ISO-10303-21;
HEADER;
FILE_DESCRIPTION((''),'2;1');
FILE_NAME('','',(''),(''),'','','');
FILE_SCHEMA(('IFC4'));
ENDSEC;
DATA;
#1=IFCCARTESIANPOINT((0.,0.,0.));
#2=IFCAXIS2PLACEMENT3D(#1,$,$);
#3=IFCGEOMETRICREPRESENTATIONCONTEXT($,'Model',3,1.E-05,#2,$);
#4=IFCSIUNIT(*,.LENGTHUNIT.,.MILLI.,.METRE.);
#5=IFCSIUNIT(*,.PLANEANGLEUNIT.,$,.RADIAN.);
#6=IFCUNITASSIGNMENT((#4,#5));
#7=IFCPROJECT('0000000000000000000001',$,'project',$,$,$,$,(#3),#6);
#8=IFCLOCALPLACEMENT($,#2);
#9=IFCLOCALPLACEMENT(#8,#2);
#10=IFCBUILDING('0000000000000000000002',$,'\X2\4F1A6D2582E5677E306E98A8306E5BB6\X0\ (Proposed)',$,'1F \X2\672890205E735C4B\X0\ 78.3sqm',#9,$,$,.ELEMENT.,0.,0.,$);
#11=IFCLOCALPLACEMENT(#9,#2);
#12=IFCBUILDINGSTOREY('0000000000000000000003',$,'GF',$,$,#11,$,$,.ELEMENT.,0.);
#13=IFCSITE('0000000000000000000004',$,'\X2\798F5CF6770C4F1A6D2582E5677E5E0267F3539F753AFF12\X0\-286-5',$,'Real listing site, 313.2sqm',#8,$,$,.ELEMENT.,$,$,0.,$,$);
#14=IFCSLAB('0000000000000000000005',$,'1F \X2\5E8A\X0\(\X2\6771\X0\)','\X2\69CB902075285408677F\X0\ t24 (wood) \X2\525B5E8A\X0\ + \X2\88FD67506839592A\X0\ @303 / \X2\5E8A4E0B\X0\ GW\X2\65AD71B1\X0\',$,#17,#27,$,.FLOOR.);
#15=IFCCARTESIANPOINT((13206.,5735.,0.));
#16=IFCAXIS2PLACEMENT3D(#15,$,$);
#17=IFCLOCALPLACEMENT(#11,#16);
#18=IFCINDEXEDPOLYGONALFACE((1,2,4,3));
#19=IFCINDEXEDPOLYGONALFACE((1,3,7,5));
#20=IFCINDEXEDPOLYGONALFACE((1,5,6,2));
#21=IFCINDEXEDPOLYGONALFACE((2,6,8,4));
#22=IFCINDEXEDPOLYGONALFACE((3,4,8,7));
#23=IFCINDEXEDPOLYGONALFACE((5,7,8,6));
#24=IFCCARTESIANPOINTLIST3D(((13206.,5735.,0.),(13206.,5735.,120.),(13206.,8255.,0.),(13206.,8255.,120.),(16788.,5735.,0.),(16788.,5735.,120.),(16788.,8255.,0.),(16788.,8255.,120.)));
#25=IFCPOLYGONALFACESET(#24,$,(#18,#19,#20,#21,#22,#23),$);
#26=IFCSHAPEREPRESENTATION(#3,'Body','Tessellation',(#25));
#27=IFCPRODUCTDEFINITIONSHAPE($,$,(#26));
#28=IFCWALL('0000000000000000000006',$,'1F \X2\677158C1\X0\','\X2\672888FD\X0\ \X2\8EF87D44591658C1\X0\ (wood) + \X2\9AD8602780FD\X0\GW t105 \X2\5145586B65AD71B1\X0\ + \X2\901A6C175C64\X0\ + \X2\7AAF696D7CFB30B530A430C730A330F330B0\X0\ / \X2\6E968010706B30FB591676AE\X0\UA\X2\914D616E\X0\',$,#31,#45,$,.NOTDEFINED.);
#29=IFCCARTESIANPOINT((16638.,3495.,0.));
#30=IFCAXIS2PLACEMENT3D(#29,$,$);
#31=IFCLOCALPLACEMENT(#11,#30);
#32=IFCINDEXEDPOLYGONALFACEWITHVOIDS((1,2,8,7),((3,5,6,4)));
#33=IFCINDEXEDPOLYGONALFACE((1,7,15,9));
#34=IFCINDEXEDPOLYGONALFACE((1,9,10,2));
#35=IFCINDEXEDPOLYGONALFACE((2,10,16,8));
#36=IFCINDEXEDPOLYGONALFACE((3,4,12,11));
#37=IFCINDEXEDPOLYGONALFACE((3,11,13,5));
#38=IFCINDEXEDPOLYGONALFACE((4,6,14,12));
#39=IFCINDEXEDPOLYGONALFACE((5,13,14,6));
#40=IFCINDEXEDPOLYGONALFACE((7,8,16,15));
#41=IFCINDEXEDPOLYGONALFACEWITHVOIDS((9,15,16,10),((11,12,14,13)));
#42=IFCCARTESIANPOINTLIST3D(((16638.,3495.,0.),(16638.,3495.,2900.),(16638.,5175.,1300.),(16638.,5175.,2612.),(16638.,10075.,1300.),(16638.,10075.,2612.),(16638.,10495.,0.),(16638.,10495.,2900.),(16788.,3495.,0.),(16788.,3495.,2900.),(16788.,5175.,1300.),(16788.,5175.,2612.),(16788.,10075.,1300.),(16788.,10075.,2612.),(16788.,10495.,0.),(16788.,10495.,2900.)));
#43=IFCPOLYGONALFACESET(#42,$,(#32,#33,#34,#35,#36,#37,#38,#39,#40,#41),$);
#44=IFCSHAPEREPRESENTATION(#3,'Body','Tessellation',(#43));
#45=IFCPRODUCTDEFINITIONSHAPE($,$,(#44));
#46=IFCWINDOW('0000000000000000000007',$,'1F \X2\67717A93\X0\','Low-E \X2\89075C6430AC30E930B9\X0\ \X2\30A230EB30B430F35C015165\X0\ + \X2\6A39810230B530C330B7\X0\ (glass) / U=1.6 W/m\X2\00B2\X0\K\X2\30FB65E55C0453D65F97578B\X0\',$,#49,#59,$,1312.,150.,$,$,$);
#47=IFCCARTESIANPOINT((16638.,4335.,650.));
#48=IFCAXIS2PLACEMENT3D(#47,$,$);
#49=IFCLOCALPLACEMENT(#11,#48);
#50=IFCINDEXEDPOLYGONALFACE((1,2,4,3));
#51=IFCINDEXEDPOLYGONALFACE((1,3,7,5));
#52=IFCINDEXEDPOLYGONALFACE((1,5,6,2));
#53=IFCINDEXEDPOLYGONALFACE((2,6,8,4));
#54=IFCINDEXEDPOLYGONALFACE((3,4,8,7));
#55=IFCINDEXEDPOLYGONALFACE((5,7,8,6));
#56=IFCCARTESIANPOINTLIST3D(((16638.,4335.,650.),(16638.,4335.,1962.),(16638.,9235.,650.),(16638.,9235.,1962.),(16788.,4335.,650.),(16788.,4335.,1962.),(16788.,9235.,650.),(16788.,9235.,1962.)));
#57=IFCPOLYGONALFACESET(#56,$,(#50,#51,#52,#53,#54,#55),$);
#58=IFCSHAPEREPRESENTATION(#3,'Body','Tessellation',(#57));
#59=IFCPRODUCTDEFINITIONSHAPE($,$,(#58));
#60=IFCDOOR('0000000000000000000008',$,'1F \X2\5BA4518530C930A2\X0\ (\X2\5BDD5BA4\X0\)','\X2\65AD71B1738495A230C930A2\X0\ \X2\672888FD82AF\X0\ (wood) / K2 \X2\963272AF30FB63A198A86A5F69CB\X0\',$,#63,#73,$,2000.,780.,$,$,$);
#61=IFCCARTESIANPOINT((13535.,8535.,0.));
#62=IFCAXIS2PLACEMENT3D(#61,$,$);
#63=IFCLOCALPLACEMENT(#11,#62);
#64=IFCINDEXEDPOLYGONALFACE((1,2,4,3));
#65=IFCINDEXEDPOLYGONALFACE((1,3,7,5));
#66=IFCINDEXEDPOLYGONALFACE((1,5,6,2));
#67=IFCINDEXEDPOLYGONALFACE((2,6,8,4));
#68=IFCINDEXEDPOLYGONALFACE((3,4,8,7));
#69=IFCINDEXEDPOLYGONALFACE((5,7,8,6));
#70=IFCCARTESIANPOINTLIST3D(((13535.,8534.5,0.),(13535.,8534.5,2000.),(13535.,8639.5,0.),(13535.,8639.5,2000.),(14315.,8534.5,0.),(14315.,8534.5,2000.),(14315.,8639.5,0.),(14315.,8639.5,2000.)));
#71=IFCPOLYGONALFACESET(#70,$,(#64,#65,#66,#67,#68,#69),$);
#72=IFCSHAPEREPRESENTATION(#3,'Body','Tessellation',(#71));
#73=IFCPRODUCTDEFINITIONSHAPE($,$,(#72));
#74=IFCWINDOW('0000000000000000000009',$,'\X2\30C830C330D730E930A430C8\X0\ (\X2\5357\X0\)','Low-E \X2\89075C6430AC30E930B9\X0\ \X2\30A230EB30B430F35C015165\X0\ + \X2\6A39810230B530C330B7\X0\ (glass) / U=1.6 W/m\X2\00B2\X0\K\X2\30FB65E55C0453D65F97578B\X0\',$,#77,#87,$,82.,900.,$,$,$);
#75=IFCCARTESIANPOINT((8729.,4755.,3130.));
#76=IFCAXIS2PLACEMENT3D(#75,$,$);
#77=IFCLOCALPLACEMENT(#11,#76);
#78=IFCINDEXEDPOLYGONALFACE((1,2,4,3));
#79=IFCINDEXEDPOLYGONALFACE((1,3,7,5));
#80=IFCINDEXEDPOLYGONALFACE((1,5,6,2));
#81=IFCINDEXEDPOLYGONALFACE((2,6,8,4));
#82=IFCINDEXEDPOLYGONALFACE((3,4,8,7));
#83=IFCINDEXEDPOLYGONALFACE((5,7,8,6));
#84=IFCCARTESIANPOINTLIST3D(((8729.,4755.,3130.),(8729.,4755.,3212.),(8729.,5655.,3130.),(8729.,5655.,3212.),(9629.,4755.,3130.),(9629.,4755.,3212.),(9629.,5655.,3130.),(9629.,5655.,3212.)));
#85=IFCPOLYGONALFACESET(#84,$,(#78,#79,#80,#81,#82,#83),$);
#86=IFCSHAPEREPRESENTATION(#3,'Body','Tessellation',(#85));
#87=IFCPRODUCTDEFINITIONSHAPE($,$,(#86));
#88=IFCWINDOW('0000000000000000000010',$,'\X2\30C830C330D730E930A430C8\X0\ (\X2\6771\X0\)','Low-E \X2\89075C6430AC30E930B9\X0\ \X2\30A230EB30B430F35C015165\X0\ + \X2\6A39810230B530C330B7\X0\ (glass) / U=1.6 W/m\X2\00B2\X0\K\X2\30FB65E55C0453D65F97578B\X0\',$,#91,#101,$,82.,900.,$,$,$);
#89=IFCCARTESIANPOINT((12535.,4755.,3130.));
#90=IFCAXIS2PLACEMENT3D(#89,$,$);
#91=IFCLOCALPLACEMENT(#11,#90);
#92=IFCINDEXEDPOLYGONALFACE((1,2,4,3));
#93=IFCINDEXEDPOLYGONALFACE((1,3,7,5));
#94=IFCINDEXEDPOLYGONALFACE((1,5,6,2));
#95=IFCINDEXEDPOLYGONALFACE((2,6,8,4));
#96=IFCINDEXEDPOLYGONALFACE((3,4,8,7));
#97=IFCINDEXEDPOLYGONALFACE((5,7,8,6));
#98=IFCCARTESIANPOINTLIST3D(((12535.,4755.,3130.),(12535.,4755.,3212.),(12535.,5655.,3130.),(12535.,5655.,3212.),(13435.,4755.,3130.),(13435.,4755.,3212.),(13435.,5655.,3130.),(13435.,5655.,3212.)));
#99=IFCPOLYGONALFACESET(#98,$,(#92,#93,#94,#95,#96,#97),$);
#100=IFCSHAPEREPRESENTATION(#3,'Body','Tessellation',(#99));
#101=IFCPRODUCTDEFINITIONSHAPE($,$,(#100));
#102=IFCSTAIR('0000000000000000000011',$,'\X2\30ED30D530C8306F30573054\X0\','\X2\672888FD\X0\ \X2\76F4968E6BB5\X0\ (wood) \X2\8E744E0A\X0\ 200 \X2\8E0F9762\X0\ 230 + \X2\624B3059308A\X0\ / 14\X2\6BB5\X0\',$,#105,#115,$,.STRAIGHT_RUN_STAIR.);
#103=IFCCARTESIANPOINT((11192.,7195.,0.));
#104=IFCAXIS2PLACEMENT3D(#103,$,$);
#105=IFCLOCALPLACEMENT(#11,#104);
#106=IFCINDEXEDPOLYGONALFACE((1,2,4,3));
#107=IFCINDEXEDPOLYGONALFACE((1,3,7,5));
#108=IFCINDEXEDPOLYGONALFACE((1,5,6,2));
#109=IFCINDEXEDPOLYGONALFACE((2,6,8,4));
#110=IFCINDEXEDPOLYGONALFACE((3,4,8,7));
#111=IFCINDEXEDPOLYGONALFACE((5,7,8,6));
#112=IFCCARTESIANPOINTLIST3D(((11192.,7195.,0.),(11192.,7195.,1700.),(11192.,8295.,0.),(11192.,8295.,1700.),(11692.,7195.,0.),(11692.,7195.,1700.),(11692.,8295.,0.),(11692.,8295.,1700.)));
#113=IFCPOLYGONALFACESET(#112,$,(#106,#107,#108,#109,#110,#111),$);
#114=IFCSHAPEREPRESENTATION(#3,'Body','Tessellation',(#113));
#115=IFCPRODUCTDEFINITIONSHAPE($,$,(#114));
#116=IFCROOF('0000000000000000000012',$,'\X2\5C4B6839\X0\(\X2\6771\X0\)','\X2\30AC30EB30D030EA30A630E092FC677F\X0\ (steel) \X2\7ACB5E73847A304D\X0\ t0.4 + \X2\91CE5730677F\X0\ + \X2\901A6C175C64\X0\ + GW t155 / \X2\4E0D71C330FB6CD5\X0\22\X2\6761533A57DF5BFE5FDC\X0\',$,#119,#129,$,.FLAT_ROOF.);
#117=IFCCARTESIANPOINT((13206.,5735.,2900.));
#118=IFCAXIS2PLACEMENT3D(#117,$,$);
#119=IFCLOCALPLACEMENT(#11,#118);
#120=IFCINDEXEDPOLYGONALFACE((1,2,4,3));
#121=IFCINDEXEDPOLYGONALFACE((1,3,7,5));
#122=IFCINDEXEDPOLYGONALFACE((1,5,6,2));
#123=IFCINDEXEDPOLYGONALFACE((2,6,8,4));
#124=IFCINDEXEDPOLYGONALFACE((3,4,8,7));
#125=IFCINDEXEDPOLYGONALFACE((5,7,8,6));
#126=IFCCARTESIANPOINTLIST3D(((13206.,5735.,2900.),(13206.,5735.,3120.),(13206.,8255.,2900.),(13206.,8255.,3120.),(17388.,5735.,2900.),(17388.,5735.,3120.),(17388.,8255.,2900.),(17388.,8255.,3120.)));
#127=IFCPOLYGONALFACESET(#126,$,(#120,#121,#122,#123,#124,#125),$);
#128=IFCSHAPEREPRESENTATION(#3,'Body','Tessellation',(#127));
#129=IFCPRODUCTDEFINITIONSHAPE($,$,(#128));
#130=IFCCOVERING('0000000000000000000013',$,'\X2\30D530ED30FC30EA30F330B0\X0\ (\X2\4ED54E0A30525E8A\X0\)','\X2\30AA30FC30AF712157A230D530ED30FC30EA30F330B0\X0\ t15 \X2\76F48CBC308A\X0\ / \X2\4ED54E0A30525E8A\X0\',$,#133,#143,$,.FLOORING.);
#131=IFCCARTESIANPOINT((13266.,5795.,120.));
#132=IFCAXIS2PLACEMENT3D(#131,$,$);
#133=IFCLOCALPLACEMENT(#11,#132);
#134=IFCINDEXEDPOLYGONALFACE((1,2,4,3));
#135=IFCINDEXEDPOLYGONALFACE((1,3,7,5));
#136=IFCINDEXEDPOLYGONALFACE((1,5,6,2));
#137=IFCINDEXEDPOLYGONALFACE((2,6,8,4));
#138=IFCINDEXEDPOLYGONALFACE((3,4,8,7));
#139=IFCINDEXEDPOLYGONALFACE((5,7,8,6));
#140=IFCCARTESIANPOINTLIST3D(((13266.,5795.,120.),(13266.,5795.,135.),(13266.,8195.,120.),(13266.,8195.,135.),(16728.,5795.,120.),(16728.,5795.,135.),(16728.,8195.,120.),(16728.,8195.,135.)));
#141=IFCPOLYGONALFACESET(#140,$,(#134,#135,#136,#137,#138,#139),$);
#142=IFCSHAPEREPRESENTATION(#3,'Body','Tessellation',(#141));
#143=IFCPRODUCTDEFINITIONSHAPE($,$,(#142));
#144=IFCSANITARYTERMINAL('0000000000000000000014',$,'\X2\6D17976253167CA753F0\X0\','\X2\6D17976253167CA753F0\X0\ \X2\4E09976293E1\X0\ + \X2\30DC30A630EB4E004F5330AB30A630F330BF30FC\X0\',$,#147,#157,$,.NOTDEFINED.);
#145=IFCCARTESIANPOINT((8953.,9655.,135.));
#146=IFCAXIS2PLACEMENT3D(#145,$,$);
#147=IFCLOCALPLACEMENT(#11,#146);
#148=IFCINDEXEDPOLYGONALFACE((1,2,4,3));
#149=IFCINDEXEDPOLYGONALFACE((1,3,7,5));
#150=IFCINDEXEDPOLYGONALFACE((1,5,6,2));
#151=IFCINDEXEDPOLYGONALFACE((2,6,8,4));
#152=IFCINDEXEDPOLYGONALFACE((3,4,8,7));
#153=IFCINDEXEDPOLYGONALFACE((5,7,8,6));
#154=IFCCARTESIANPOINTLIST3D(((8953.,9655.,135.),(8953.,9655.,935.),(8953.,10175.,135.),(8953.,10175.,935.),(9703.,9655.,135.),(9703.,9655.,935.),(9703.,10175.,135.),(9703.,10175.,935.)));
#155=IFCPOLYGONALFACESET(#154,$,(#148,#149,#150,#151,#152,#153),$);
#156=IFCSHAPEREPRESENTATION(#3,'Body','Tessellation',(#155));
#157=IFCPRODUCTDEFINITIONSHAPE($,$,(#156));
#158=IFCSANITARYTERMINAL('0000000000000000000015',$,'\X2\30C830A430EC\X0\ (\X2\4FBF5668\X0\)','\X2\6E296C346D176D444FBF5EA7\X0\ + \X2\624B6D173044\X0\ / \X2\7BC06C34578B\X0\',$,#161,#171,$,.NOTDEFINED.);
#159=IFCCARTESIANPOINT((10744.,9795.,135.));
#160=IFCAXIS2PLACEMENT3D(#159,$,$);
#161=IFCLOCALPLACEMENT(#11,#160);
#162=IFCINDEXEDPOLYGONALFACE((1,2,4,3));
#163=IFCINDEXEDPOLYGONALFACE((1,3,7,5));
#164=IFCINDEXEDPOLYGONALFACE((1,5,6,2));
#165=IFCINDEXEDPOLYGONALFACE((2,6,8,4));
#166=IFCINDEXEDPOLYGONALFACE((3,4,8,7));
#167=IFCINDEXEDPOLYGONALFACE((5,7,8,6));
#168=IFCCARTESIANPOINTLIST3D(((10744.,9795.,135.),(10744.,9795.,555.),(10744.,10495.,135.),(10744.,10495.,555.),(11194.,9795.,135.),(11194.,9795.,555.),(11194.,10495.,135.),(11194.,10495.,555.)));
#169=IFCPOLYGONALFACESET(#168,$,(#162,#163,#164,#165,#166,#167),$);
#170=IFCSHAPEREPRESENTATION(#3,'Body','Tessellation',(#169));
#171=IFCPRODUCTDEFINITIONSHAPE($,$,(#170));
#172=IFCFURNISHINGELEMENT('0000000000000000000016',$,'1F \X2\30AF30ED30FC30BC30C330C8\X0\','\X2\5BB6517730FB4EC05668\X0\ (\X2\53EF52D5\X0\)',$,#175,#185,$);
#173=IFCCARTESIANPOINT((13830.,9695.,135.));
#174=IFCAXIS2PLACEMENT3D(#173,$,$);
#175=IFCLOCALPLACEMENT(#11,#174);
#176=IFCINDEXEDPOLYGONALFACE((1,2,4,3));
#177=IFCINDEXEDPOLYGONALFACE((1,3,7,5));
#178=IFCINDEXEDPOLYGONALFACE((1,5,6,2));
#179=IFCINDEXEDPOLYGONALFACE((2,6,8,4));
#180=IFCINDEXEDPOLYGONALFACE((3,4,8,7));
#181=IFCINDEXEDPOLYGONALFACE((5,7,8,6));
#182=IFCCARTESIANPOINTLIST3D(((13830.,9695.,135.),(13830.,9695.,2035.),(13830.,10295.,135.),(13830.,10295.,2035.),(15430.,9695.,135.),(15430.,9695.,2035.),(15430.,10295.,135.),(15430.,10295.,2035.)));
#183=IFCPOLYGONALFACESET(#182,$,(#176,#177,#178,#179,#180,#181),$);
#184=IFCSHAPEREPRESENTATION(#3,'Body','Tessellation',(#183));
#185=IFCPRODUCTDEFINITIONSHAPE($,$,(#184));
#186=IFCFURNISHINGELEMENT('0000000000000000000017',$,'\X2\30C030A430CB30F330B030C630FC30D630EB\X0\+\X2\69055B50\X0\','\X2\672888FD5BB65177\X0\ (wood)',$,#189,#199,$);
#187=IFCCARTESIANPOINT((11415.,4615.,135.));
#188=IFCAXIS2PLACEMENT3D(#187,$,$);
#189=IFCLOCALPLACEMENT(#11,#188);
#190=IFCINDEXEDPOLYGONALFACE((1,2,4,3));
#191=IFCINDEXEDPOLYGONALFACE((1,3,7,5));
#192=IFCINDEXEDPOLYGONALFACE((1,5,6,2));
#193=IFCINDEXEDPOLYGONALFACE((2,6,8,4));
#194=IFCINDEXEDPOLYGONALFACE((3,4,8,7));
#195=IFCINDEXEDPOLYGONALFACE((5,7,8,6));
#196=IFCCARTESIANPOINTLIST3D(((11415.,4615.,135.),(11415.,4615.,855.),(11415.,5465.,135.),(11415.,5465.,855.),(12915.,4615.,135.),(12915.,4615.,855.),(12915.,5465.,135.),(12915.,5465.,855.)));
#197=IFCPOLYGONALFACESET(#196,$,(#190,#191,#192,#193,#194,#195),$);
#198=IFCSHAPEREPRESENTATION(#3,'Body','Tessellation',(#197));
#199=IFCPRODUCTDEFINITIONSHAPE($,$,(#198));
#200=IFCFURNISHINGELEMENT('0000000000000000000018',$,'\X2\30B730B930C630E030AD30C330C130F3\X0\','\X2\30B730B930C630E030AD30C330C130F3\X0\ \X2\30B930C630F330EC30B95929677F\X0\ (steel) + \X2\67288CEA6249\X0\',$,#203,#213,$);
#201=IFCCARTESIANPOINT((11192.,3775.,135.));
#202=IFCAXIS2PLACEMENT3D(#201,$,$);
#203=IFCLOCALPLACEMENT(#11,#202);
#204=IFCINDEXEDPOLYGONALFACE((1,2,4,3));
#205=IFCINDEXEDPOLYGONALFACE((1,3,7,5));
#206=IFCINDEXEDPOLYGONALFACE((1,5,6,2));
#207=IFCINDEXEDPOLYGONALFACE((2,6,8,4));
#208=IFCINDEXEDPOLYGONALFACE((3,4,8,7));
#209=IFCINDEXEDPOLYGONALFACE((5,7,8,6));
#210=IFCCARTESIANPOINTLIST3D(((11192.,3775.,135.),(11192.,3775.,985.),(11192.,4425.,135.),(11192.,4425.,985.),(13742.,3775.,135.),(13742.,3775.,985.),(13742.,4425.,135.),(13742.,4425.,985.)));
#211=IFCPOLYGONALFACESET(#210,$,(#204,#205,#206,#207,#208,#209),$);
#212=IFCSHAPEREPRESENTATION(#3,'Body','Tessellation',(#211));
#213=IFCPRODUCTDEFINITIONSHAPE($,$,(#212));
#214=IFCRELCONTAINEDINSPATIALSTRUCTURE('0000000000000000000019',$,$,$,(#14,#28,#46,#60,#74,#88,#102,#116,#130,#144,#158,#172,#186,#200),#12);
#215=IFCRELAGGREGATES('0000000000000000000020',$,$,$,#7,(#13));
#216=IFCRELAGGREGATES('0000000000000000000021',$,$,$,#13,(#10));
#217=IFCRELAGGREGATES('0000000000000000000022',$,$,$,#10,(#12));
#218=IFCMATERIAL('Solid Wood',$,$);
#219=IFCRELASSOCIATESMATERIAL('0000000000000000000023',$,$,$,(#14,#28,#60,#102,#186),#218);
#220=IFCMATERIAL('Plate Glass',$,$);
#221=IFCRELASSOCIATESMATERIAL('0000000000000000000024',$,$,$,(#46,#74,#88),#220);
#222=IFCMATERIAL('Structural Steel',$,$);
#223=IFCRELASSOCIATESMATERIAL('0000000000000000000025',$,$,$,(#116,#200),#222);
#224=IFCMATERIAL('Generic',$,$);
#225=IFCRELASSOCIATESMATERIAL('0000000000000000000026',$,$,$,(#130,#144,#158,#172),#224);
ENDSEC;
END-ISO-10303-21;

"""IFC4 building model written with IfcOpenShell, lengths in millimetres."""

from ifc_helpers import new_model, si_unit, frame, frame_2d, origin, place, context, project, spatial, rectangle, extrude, material, element, fill, save


model = new_model("IFC4")

# Units and contexts
model_context = context("Model", 3, precision=1e-05, world=origin())
ifc_project = project(units=[si_unit("LENGTHUNIT", "METRE", prefix="MILLI"), si_unit("PLANEANGLEUNIT", "RADIAN")], contexts=[model_context])

# Site, building, storey
site_placement = place(None, origin())
site = spatial("IfcSite", under=ifc_project, at=site_placement, Name="福島県会津若松市柳原町２-286-5", ObjectType="Real listing site, 313.2sqm", CompositionType="ELEMENT", RefElevation=0.0)
building_placement = place(site_placement, origin())
building = spatial("IfcBuilding", under=site, at=building_placement, Name="会津若松の風の家 (Proposed)", ObjectType="1F 木造平屋 78.3sqm", CompositionType="ELEMENT", ElevationOfRefHeight=0.0, ElevationOfTerrain=0.0)
storey_placement = place(building_placement, origin())
storey = spatial("IfcBuildingStorey", under=building, at=storey_placement, Name="GF", CompositionType="ELEMENT", Elevation=0.0)

# Slab
ifc_material_1 = material(Name="Solid Wood")
slab_1_placement = place(storey_placement, frame((13206.0, 5735.0, 0.0)))
element("IfcSlab", 1, at=slab_1_placement, inside=storey, material=ifc_material_1, Name="1F 床(東)", Description="構造用合板 t24 (wood) 剛床 + 製材根太 @303 / 床下 GW断熱", PredefinedType="FLOOR", context=model_context, shape_type="SweptSolid", body=[
    extrude(rectangle(XDim=3582.0, YDim=2520.0, at=frame_2d((1791.0, 1260.0))), frame((13206.0, 5735.0, 0.0)), (0.0, 0.0, 1.0), 120.0),
])

# Wall, opening, window
wall_1_placement = place(storey_placement, frame((16638.0, 3495.0, 0.0)))
wall_1 = element("IfcWall", 2, at=wall_1_placement, inside=storey, material=ifc_material_1, Name="1F 東壁", Description="木製 軸組外壁 (wood) + 高性能GW t105 充填断熱 + 通気層 + 窯業系サイディング / 準耐火・外皮UA配慮", PredefinedType="NOTDEFINED", context=model_context, shape_type="SweptSolid", body=[
    extrude(rectangle(XDim=150.0, YDim=7000.0, at=frame_2d((75.0, 3500.0))), frame((16638.0, 3495.0, 0.0)), (0.0, 0.0, 1.0), 2900.0),
])
opening_1_placement = place(storey_placement, frame((16638.0, 4335.0, 650.0)))
opening_1 = element("IfcOpeningElement", 3, at=opening_1_placement, cuts=wall_1, PredefinedType="NOTDEFINED", context=model_context, shape_type="SweptSolid", body=[
    extrude(rectangle(XDim=150.0, YDim=4900.0, at=frame_2d((75.0, 2450.0))), frame((16638.0, 4335.0, 650.0)), (0.0, 0.0, 1.0), 1312.0),
])
ifc_material_2 = material(Name="Plate Glass")
window_1_placement = place(storey_placement, frame((16638.0, 4335.0, 650.0)))
window_1 = element("IfcWindow", 4, at=window_1_placement, inside=storey, material=ifc_material_2, Name="1F 東窓", Description="Low-E 複層ガラス アルゴン封入 + 樹脂サッシ (glass) / U=1.6 W/m²K・日射取得型", OverallHeight=1312.0, OverallWidth=150.0, context=model_context, shape_type="SweptSolid", body=[
    extrude(rectangle(XDim=150.0, YDim=4900.0, at=frame_2d((75.0, 2450.0))), frame((16638.0, 4335.0, 650.0)), (0.0, 0.0, 1.0), 1312.0),
])
fill(opening_1, window_1)

# Door
door_placement = place(storey_placement, frame((13535.0, 8535.0, 0.0)))
element("IfcDoor", 5, at=door_placement, inside=storey, material=ifc_material_1, Name="1F 室内ドア (寝室)", Description="断熱玄関ドア 木製芯 (wood) / K2 防犯・採風機構", OverallHeight=2000.0, OverallWidth=780.0, context=model_context, shape_type="SweptSolid", body=[
    extrude(rectangle(XDim=780.0, YDim=105.0, at=frame_2d((390.0, 52.0))), frame((13535.0, 8535.0, 0.0)), (0.0, 0.0, 1.0), 2000.0),
])

# Windows
window_2_placement = place(storey_placement, frame((8729.0, 4755.0, 3130.0)))
element("IfcWindow", 6, at=window_2_placement, inside=storey, material=ifc_material_2, Name="トップライト (南)", Description="Low-E 複層ガラス アルゴン封入 + 樹脂サッシ (glass) / U=1.6 W/m²K・日射取得型", OverallHeight=82.0, OverallWidth=900.0, context=model_context, shape_type="SweptSolid", body=[
    extrude(rectangle(XDim=900.0, YDim=900.0, at=frame_2d((450.0, 450.0))), frame((8729.0, 4755.0, 3130.0)), (0.0, 0.0, 1.0), 82.0),
])
window_3_placement = place(storey_placement, frame((12535.0, 4755.0, 3130.0)))
element("IfcWindow", 7, at=window_3_placement, inside=storey, material=ifc_material_2, Name="トップライト (東)", Description="Low-E 複層ガラス アルゴン封入 + 樹脂サッシ (glass) / U=1.6 W/m²K・日射取得型", OverallHeight=82.0, OverallWidth=900.0, context=model_context, shape_type="SweptSolid", body=[
    extrude(rectangle(XDim=900.0, YDim=900.0, at=frame_2d((450.0, 450.0))), frame((12535.0, 4755.0, 3130.0)), (0.0, 0.0, 1.0), 82.0),
])

# Stair
stair_placement = place(storey_placement, frame((11192.0, 7195.0, 0.0)))
element("IfcStair", 8, at=stair_placement, inside=storey, material=ifc_material_1, Name="ロフトはしご", Description="木製 直階段 (wood) 蹴上 200 踏面 230 + 手すり / 14段", PredefinedType="STRAIGHT_RUN_STAIR", context=model_context, shape_type="SweptSolid", body=[
    extrude(rectangle(XDim=500.0, YDim=1100.0, at=frame_2d((250.0, 550.0))), frame((11192.0, 7195.0, 0.0)), (0.0, 0.0, 1.0), 1700.0),
])

# Roof
ifc_material_3 = material(Name="Structural Steel")
roof_placement = place(storey_placement, frame((13206.0, 5735.0, 2900.0)))
element("IfcRoof", 9, at=roof_placement, inside=storey, material=ifc_material_3, Name="屋根(東)", Description="ガルバリウム鋼板 (steel) 立平葺き t0.4 + 野地板 + 通気層 + GW t155 / 不燃・法22条区域対応", PredefinedType="FLAT_ROOF", context=model_context, shape_type="SweptSolid", body=[
    extrude(rectangle(XDim=4182.0, YDim=2520.0, at=frame_2d((2091.0, 1260.0))), frame((13206.0, 5735.0, 2900.0)), (0.0, 0.0, 1.0), 220.0),
])

# Covering
ifc_material_4 = material(Name="Generic")
covering_placement = place(storey_placement, frame((13266.0, 5795.0, 120.0)))
element("IfcCovering", 10, at=covering_placement, inside=storey, material=ifc_material_4, Name="フローリング (仕上げ床)", Description="オーク無垢フローリング t15 直貼り / 仕上げ床", PredefinedType="FLOORING", context=model_context, shape_type="SweptSolid", body=[
    extrude(rectangle(XDim=3462.0, YDim=2400.0, at=frame_2d((1731.0, 1200.0))), frame((13266.0, 5795.0, 120.0)), (0.0, 0.0, 1.0), 15.0),
])

# Sanitary terminals
sanitary_terminal_1_placement = place(storey_placement, frame((8953.0, 9655.0, 135.0)))
element("IfcSanitaryTerminal", 11, at=sanitary_terminal_1_placement, inside=storey, material=ifc_material_4, Name="洗面化粧台", Description="洗面化粧台 三面鏡 + ボウル一体カウンター", PredefinedType="NOTDEFINED", context=model_context, shape_type="SweptSolid", body=[
    extrude(rectangle(XDim=750.0, YDim=520.0, at=frame_2d((375.0, 260.0))), frame((8953.0, 9655.0, 135.0)), (0.0, 0.0, 1.0), 800.0),
])
sanitary_terminal_2_placement = place(storey_placement, frame((10744.0, 9795.0, 135.0)))
element("IfcSanitaryTerminal", 12, at=sanitary_terminal_2_placement, inside=storey, material=ifc_material_4, Name="トイレ (便器)", Description="温水洗浄便座 + 手洗い / 節水型", PredefinedType="NOTDEFINED", context=model_context, shape_type="SweptSolid", body=[
    extrude(rectangle(XDim=450.0, YDim=700.0, at=frame_2d((225.0, 350.0))), frame((10744.0, 9795.0, 135.0)), (0.0, 0.0, 1.0), 420.0),
])

# Furnishing elements
furnishing_1_placement = place(storey_placement, frame((13830.0, 9695.0, 135.0)))
element("IfcFurnishingElement", 13, at=furnishing_1_placement, inside=storey, material=ifc_material_4, Name="1F クローゼット", Description="家具・什器 (可動)", context=model_context, shape_type="SweptSolid", body=[
    extrude(rectangle(XDim=1600.0, YDim=600.0, at=frame_2d((800.0, 300.0))), frame((13830.0, 9695.0, 135.0)), (0.0, 0.0, 1.0), 1900.0),
])
furnishing_2_placement = place(storey_placement, frame((11415.0, 4615.0, 135.0)))
element("IfcFurnishingElement", 14, at=furnishing_2_placement, inside=storey, material=ifc_material_1, Name="ダイニングテーブル+椅子", Description="木製家具 (wood)", context=model_context, shape_type="SweptSolid", body=[
    extrude(rectangle(XDim=1500.0, YDim=850.0, at=frame_2d((750.0, 425.0))), frame((11415.0, 4615.0, 135.0)), (0.0, 0.0, 1.0), 720.0),
])
furnishing_3_placement = place(storey_placement, frame((11192.0, 3775.0, 135.0)))
element("IfcFurnishingElement", 15, at=furnishing_3_placement, inside=storey, material=ifc_material_3, Name="システムキッチン", Description="システムキッチン ステンレス天板 (steel) + 木質扉", context=model_context, shape_type="SweptSolid", body=[
    extrude(rectangle(XDim=2550.0, YDim=650.0, at=frame_2d((1275.0, 325.0))), frame((11192.0, 3775.0, 135.0)), (0.0, 0.0, 1.0), 850.0),
])

save(model, "model.ifc")
